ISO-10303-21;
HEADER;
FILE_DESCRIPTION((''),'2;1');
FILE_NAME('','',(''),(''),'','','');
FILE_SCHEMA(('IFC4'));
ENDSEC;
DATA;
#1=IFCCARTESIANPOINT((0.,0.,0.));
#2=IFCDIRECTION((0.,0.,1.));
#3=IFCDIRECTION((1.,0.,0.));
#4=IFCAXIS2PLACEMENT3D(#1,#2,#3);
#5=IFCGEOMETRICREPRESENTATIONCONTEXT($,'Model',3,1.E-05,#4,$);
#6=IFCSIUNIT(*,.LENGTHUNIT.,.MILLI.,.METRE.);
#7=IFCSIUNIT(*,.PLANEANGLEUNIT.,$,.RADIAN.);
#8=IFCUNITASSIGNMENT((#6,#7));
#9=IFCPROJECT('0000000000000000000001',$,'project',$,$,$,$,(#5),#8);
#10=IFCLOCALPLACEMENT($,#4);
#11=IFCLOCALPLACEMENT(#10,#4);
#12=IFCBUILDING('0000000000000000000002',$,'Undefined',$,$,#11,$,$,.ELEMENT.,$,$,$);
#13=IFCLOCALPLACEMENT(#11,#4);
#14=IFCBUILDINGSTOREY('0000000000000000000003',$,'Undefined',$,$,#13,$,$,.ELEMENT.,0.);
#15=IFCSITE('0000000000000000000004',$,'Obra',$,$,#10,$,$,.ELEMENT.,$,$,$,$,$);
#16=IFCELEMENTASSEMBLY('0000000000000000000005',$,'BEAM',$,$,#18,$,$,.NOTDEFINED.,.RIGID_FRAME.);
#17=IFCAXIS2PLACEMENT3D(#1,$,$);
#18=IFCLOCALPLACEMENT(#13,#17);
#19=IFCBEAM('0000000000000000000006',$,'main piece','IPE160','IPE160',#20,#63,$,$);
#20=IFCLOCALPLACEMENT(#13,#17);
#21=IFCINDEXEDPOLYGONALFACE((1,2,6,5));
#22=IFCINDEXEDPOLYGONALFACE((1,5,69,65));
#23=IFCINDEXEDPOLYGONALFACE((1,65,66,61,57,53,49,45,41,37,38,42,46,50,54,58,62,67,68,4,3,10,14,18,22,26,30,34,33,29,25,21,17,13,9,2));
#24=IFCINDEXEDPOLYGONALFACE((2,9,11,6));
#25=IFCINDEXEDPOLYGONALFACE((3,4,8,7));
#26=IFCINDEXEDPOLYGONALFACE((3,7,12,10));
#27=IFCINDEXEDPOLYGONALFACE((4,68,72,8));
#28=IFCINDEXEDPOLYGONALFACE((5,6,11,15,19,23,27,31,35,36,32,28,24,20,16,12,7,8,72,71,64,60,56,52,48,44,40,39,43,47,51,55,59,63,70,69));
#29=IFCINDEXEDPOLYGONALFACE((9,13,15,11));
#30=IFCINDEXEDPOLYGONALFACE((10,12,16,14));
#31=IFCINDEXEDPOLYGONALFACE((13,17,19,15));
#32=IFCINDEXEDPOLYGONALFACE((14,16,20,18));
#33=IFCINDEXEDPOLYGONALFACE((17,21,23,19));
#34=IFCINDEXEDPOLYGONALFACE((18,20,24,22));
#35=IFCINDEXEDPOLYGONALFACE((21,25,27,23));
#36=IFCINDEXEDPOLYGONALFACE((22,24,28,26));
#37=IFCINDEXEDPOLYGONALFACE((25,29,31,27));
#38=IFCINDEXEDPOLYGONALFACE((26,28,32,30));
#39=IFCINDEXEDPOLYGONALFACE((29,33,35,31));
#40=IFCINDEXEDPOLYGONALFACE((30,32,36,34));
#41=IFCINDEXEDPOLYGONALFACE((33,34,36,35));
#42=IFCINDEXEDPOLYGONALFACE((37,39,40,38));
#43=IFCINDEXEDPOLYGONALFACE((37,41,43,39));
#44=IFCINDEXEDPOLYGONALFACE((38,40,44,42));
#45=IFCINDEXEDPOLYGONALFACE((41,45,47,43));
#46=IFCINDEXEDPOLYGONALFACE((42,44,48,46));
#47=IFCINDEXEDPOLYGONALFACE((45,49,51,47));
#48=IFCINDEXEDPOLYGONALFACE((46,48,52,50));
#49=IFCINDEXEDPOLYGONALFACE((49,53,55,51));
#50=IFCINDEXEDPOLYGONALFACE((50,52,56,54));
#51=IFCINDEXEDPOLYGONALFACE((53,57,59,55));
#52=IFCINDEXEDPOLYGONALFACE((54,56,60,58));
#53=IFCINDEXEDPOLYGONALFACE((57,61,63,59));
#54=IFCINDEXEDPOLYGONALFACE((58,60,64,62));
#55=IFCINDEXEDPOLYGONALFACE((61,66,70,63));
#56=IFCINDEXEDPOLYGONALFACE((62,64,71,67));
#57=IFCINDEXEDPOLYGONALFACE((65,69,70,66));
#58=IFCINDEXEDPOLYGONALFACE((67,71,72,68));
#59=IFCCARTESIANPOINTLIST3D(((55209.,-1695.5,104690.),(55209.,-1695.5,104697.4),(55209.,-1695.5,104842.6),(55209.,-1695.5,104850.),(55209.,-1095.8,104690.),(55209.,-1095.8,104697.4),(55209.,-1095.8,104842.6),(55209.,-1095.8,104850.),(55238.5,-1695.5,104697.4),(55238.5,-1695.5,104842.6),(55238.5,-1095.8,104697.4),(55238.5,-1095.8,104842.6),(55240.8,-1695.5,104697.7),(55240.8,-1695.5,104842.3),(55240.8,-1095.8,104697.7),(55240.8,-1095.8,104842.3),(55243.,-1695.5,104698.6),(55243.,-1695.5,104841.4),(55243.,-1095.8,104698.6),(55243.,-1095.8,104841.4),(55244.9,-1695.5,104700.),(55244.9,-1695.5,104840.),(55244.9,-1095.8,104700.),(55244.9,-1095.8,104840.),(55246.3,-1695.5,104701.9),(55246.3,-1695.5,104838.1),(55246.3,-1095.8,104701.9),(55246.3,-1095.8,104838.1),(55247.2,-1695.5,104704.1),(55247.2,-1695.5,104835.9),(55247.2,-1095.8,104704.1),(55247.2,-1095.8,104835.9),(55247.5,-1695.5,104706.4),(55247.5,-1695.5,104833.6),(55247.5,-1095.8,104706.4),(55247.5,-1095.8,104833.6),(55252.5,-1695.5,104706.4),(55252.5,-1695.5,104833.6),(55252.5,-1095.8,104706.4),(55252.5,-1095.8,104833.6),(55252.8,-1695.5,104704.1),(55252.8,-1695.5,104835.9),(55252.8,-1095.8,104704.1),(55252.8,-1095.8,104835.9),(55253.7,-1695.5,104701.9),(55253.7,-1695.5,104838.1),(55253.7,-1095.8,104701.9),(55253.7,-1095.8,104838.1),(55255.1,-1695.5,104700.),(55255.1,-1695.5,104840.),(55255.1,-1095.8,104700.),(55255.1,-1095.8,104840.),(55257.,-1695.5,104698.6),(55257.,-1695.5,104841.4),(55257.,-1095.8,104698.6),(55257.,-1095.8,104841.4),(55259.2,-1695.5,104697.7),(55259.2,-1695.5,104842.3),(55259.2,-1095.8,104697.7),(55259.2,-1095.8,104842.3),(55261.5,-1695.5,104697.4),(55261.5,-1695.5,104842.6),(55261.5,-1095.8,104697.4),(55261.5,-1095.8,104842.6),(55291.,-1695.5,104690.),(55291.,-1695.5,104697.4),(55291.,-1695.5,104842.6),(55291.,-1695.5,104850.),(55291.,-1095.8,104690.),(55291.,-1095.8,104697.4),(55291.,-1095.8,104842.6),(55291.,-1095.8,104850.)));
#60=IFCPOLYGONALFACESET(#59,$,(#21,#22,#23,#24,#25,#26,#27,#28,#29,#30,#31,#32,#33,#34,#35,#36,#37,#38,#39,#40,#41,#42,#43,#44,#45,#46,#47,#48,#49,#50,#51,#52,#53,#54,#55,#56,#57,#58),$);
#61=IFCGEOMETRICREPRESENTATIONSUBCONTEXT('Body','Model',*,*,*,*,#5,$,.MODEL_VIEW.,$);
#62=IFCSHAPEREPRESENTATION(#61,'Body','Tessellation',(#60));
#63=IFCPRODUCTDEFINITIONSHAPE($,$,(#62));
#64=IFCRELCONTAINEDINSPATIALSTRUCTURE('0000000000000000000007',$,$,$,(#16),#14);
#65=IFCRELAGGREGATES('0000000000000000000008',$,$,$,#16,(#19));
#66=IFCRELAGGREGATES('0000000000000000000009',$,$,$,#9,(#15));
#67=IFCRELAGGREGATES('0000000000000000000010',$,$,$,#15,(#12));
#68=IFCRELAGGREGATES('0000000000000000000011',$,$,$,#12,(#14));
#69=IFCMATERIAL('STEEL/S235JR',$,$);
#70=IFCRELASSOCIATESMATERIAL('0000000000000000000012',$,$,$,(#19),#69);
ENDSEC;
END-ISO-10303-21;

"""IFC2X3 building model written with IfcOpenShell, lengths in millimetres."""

from ifc_helpers import new_model, si_unit, frame, origin_with_axes, origin_2d_with_axis, place, context, subcontext, project, spatial, i_section, extrude, material, element, aggregate, save


model = new_model("IFC2X3")

# Units and contexts
model_context = context("Model", 3, precision=1e-05, world=origin_with_axes())
body_context = subcontext(model_context, "Body", "Model", "MODEL_VIEW")
ifc_project = project(units=[si_unit("LENGTHUNIT", "METRE", prefix="MILLI"), si_unit("PLANEANGLEUNIT", "RADIAN")], contexts=[model_context])

# Site, building, storey
site_placement = place(None, origin_with_axes())
site = spatial("IfcSite", under=ifc_project, at=site_placement, Name="Obra", CompositionType="ELEMENT")
building_placement = place(site_placement, origin_with_axes())
building = spatial("IfcBuilding", under=site, at=building_placement, Name="Undefined", CompositionType="ELEMENT")
storey_placement = place(building_placement, origin_with_axes())
storey = spatial("IfcBuildingStorey", under=building, at=storey_placement, Name="Undefined", CompositionType="ELEMENT", Elevation=0.0)

# Element assembly, beam
ifc_material_1 = material(Name="STEEL/S235JR")
assembly_1_placement = place(storey_placement, origin_with_axes())
assembly_1 = element("IfcElementAssembly", 1, at=assembly_1_placement, inside=storey, Name="BEAM", AssemblyPlace="NOTDEFINED", PredefinedType="RIGID_FRAME")
beam_1_placement = place(assembly_1_placement, frame((55250.0, -1095.8, 104770.0), z_axis=(0.0, 0.0, 1.0), x_axis=(0.0, -1.0, 0.0)))
beam_1 = element("IfcBeam", 2, at=beam_1_placement, material=ifc_material_1, Name="main piece", Description="IPE160", ObjectType="IPE160", context=body_context, shape_type="SweptSolid", body=[
    extrude(i_section(OverallWidth=82.0, OverallDepth=160.0, WebThickness=5.0, FlangeThickness=7.4, FilletRadius=9.0, at=origin_2d_with_axis()), frame((599.7, 0.0, 0.0), z_axis=(-1.0, 0.0, 0.0), x_axis=(0.0, -1.0, 0.0)), (0.0, 0.0, 1.0), 599.7),
])
aggregate(assembly_1, [beam_1])

save(model, "model.ifc")
